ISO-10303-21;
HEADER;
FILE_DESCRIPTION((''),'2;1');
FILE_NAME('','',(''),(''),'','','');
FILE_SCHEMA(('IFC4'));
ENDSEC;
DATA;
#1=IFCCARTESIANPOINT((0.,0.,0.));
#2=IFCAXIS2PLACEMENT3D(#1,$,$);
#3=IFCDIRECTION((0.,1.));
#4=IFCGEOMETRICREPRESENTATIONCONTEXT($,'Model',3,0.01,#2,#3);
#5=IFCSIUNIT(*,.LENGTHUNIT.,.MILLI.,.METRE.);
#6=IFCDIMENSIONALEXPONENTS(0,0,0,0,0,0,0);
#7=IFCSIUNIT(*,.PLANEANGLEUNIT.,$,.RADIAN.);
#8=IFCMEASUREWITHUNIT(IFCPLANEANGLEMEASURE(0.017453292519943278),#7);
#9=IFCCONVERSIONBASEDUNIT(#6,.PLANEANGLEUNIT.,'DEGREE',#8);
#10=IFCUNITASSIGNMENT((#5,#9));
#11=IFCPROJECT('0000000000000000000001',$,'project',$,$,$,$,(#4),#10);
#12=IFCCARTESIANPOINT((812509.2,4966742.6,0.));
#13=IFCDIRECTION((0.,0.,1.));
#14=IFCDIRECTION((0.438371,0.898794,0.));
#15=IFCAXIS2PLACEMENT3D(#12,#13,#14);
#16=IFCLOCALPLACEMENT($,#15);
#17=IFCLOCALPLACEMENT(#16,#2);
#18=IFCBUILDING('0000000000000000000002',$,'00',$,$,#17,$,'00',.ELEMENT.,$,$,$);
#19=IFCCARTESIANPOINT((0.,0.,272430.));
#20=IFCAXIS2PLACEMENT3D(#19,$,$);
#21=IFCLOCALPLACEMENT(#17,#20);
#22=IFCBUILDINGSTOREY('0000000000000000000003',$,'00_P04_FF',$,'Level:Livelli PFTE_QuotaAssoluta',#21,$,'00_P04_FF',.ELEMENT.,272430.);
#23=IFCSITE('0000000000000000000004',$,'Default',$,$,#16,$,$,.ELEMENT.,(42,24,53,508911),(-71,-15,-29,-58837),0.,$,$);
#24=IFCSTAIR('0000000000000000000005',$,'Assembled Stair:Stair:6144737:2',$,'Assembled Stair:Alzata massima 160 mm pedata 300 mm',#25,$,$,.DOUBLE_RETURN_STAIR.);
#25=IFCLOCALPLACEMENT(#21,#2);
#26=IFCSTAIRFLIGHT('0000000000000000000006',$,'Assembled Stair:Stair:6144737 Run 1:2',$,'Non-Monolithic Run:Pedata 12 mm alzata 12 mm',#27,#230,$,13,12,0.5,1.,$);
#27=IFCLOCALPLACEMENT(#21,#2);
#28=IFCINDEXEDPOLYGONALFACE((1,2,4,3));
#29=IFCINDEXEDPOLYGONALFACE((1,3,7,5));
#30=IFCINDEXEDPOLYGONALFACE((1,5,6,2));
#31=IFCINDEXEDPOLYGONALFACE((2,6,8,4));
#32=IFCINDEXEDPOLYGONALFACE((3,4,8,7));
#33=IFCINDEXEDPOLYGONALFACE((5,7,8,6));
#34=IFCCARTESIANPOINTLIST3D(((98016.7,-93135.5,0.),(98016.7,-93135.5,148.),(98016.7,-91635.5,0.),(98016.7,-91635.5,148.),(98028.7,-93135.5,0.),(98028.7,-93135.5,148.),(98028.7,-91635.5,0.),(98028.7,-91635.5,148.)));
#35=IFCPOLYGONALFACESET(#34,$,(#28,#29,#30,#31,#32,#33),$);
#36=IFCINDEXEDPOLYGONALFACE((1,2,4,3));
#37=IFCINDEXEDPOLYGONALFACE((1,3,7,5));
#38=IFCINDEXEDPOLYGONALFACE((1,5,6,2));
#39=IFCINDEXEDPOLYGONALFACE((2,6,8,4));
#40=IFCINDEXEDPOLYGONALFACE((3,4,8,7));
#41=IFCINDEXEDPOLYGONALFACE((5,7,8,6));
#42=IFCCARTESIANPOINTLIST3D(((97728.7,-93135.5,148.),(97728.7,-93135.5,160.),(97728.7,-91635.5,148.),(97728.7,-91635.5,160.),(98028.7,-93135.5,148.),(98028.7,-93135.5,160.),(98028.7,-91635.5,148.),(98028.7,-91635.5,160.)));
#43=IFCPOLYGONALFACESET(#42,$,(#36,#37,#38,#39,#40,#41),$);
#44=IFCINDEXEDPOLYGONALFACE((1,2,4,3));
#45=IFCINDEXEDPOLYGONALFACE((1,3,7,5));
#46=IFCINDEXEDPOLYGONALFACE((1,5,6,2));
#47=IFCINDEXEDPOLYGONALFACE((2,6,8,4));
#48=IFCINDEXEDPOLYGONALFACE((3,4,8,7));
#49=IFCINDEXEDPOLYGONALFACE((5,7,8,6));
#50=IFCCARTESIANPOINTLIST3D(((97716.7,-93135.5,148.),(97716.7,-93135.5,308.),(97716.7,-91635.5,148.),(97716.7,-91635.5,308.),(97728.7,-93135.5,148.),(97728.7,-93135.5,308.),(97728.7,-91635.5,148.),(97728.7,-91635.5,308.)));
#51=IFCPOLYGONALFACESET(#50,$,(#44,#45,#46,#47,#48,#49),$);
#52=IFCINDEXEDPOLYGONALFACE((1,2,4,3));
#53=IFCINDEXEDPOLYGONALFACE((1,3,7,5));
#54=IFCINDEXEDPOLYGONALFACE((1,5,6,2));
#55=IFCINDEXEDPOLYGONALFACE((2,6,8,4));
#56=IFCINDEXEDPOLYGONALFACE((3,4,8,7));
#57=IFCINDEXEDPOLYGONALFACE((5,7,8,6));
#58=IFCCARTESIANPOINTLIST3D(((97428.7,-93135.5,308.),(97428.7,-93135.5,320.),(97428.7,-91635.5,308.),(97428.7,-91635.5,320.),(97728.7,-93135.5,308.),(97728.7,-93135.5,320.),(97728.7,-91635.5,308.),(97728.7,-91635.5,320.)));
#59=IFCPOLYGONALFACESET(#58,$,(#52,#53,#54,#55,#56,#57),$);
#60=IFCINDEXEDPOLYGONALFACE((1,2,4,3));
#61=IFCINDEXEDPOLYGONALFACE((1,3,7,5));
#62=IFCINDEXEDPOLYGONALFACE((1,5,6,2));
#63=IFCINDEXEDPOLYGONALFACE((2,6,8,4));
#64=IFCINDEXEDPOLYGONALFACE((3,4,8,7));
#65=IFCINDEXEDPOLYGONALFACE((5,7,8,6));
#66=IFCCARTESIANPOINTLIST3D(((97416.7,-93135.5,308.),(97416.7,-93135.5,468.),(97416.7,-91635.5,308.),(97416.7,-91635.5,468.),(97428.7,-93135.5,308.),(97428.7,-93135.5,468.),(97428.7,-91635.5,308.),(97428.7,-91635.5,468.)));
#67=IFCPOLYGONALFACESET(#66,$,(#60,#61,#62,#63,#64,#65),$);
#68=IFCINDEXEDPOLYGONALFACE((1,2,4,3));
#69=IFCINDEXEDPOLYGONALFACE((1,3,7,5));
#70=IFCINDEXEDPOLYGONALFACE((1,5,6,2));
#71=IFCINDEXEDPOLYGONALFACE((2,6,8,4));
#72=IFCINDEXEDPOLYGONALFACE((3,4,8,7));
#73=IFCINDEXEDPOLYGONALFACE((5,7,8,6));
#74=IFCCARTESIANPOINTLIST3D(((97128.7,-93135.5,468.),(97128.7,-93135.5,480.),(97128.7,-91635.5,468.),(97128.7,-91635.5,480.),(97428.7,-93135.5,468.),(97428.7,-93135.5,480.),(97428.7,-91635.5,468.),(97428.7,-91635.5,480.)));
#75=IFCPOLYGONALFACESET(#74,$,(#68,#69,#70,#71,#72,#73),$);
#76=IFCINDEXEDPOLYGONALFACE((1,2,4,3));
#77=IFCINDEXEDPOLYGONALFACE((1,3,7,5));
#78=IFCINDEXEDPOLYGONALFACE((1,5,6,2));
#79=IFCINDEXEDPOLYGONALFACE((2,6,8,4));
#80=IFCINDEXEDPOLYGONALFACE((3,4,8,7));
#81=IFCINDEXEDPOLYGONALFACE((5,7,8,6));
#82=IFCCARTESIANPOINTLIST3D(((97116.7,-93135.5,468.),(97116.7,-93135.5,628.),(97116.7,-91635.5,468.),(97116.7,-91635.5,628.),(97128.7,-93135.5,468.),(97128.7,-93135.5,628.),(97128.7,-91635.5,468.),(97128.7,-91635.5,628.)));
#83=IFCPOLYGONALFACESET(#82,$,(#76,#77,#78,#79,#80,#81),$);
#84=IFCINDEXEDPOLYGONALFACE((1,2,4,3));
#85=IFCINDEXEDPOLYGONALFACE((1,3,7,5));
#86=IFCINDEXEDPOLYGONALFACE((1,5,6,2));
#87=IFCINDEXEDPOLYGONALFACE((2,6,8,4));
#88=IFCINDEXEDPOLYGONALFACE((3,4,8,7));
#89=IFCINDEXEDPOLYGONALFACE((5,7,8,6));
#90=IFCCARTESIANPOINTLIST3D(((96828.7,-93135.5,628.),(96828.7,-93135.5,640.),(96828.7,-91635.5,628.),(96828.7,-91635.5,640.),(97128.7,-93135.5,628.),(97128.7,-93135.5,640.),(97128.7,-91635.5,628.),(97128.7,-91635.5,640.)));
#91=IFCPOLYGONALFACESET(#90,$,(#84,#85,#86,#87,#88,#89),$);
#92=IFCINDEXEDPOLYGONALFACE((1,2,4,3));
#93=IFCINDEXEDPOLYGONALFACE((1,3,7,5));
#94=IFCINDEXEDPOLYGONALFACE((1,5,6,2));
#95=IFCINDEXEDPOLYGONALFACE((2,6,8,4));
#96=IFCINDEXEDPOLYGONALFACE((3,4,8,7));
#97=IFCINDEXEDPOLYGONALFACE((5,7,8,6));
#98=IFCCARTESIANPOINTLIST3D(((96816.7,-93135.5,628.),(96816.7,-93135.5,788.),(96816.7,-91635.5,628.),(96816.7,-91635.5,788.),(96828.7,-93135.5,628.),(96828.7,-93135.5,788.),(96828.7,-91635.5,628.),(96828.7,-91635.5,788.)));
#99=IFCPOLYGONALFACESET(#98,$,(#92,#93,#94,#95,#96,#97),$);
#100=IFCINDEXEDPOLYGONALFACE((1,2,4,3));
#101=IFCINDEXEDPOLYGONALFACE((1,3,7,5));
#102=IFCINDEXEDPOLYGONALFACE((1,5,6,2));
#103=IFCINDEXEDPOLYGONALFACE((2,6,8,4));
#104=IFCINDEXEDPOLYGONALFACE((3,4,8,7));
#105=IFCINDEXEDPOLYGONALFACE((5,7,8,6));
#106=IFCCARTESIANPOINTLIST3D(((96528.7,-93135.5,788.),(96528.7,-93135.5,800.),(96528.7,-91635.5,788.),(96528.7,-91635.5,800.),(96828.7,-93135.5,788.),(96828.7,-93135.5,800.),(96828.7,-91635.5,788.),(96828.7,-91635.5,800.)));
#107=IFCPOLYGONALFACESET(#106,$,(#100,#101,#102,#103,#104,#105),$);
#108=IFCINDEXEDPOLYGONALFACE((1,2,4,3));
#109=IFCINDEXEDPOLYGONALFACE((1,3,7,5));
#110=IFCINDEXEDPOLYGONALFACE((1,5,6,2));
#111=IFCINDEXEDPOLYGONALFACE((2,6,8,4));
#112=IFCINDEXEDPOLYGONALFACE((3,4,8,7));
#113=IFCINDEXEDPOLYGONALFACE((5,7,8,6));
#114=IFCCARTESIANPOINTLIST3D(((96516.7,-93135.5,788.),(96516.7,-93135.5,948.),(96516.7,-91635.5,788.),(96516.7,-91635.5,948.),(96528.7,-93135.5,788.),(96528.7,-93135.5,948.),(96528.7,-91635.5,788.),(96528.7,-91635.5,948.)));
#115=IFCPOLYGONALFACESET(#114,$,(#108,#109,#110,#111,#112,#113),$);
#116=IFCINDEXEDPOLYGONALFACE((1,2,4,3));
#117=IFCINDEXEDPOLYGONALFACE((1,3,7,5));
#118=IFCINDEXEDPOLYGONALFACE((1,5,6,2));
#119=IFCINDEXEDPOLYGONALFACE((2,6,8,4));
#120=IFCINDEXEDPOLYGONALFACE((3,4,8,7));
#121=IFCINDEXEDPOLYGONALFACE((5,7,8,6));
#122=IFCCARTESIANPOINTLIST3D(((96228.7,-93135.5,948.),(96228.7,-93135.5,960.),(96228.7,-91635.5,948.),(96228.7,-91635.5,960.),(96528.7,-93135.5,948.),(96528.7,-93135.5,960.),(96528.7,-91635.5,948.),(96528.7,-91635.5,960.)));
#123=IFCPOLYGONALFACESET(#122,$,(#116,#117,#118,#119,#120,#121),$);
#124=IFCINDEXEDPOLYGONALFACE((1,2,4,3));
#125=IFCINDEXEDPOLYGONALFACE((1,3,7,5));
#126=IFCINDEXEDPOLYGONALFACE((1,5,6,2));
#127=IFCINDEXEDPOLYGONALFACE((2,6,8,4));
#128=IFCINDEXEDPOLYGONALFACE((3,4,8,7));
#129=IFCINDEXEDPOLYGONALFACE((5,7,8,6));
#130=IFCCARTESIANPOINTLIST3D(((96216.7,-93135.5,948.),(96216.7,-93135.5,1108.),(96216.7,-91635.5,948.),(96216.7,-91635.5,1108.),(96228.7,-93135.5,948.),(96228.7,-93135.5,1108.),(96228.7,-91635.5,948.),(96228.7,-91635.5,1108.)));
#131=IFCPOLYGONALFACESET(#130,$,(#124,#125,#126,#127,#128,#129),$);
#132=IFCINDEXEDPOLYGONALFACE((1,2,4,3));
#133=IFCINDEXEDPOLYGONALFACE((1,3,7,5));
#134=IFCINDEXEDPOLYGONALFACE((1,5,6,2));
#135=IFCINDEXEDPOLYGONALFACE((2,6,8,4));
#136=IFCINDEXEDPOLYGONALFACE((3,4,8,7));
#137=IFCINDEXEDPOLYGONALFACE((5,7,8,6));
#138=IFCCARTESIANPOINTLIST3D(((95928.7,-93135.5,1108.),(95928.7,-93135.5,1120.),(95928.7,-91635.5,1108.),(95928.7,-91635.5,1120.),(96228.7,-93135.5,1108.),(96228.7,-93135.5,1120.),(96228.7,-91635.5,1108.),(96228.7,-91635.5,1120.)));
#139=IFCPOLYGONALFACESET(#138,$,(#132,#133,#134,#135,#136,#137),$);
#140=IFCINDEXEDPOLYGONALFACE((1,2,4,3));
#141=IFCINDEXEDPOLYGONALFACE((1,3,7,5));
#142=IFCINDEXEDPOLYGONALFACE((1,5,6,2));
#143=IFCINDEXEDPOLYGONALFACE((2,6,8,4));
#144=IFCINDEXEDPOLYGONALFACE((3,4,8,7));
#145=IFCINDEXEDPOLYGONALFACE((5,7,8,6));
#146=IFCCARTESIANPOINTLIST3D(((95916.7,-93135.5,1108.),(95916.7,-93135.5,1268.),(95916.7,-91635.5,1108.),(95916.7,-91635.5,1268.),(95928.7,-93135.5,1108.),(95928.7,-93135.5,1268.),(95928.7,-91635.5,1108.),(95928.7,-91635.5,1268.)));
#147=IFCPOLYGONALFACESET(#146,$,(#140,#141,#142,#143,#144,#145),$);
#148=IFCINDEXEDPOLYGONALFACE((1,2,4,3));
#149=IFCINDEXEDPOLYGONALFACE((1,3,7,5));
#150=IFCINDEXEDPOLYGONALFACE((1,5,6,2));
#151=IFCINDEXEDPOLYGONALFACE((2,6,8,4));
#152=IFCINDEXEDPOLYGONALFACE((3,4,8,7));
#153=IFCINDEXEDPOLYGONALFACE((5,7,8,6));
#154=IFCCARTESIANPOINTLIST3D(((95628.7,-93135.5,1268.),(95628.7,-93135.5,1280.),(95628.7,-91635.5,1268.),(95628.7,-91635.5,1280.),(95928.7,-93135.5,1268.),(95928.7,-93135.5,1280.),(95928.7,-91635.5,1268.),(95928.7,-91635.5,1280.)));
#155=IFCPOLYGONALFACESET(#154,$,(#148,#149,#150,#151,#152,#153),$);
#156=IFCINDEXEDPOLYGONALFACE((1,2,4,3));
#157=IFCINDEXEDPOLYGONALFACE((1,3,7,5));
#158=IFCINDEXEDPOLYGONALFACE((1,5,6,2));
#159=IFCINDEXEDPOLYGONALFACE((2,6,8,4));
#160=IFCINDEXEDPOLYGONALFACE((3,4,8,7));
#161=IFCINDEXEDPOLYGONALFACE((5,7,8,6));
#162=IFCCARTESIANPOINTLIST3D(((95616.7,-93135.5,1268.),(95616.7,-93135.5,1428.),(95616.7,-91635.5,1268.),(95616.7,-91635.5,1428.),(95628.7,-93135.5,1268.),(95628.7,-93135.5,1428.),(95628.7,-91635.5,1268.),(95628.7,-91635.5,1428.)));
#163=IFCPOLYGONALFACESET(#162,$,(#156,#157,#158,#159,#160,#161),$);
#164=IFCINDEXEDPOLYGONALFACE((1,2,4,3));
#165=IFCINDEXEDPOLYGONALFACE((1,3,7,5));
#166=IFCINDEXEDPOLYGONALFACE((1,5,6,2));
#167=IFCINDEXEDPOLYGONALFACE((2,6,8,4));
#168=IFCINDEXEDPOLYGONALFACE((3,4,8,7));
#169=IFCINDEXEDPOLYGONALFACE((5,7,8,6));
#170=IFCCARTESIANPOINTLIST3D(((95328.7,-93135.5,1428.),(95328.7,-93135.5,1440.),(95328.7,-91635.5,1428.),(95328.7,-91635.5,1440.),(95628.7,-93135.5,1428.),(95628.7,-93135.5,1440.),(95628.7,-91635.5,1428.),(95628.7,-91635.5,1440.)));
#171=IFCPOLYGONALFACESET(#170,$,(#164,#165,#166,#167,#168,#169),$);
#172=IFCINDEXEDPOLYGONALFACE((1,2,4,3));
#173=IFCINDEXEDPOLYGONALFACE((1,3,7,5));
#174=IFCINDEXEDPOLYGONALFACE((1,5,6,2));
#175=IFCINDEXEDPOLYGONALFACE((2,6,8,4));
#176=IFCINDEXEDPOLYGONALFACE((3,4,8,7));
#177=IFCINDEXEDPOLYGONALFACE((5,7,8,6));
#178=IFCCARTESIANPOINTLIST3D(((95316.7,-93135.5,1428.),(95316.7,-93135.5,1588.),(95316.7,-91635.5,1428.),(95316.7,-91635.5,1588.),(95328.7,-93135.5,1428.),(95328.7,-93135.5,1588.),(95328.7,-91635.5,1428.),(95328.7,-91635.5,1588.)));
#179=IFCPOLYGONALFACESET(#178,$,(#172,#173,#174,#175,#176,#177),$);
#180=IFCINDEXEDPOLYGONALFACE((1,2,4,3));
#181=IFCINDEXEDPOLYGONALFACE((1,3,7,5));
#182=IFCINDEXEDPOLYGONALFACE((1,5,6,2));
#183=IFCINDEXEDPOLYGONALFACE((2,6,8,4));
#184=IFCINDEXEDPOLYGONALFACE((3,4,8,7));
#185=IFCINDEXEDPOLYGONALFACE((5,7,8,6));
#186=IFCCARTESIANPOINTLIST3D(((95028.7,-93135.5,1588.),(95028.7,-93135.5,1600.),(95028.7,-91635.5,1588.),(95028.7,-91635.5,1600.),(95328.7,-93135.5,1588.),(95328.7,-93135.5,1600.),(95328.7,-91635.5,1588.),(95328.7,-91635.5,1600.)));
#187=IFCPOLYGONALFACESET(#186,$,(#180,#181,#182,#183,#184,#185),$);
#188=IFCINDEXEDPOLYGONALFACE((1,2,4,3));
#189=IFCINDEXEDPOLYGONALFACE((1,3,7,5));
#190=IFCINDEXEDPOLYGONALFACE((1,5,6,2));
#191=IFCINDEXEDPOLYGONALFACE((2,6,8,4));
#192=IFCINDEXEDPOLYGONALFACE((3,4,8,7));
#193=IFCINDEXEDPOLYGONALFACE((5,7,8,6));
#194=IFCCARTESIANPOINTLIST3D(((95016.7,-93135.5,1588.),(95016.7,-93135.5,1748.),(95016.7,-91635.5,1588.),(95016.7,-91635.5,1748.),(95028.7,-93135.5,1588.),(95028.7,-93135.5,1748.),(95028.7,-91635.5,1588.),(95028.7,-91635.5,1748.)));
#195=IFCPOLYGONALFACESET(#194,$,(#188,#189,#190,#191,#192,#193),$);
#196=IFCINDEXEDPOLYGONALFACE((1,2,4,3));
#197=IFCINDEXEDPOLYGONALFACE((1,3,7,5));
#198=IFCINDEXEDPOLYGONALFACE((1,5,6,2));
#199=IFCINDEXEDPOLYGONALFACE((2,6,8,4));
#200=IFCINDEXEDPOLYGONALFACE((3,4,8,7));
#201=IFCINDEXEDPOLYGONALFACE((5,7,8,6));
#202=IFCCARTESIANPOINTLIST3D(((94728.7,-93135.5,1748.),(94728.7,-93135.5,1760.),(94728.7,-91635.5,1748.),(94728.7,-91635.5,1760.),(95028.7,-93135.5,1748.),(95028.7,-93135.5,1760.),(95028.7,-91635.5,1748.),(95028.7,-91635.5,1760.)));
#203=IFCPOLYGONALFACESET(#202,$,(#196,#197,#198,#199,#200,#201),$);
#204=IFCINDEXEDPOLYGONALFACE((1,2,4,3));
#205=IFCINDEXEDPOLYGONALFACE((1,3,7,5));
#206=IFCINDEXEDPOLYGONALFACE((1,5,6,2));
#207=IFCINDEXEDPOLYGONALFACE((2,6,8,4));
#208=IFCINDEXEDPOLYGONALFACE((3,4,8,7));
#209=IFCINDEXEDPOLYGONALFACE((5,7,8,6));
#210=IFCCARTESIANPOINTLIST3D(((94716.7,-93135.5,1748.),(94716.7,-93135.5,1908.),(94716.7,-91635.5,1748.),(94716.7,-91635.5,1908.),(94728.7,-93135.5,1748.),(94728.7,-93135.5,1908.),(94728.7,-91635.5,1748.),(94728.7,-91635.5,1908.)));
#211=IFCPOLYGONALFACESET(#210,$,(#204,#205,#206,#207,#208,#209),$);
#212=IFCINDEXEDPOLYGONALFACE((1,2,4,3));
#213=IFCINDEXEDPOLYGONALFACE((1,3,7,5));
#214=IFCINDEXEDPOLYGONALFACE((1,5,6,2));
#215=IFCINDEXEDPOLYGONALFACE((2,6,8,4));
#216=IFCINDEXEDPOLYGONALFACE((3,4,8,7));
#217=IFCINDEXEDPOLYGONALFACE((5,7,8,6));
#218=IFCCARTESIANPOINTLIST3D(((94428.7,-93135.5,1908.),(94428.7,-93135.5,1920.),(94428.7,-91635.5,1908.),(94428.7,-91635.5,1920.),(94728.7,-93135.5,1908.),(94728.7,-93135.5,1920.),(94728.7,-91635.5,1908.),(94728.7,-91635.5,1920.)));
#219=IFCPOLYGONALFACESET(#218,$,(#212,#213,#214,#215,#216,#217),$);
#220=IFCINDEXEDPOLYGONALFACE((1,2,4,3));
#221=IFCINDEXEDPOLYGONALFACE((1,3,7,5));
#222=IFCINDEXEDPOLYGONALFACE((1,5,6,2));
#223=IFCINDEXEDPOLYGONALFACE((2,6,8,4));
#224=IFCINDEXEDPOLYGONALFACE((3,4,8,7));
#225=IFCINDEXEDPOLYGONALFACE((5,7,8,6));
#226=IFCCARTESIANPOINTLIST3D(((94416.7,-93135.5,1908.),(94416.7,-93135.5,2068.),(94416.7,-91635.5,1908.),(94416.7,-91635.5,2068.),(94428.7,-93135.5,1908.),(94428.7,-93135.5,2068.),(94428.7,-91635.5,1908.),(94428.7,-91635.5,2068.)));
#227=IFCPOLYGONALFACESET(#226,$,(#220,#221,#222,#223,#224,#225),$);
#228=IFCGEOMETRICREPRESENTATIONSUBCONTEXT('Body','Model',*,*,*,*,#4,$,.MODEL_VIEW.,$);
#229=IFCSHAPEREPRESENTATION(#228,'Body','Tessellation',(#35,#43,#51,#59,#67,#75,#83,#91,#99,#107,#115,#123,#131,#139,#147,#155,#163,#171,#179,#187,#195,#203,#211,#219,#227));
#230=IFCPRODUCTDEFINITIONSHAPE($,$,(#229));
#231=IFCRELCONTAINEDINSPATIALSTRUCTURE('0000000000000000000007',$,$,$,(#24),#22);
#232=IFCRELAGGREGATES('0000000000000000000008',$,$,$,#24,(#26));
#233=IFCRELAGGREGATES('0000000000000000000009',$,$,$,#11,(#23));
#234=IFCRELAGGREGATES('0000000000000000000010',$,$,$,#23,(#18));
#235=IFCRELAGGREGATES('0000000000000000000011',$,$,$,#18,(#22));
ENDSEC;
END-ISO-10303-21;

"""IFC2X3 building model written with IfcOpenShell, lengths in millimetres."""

from ifc_helpers import new_model, entity, si_unit, converted_unit, direction, frame, frame_2d, origin, origin_2d_with_axis, place, context, subcontext, project, spatial, rectangle, extrude, element, aggregate, save


model = new_model("IFC2X3")

# Units and contexts
model_context = context("Model", 3, precision=0.01, world=origin(), true_north=direction((0.0, 1.0)))
body_context = subcontext(model_context, "Body", "Model", "MODEL_VIEW")
ifc_project = project(units=[si_unit("LENGTHUNIT", "METRE", prefix="MILLI"), converted_unit("PLANEANGLEUNIT", "DEGREE", entity("IfcPlaneAngleMeasure", 0.017453292519943278), si_unit("PLANEANGLEUNIT", "RADIAN"), dimensions=[0, 0, 0, 0, 0, 0, 0])], contexts=[model_context])

# Site, building, storey
site_placement = place(None, frame((812509.2, 4966742.6, 0.0), z_axis=(0.0, 0.0, 1.0), x_axis=(0.438371, 0.898794, 0.0)))
site = spatial("IfcSite", under=ifc_project, at=site_placement, Name="Default", CompositionType="ELEMENT", RefLatitude=(42, 24, 53, 508911), RefLongitude=(-71, -15, -29, -58837), RefElevation=0.0)
building_placement = place(site_placement, origin())
building = spatial("IfcBuilding", under=site, at=building_placement, Name="00", LongName="00", CompositionType="ELEMENT")
storey_placement = place(building_placement, frame((0.0, 0.0, 272430.0)))
storey = spatial("IfcBuildingStorey", under=building, at=storey_placement, Name="00_P04_FF", ObjectType="Level:Livelli PFTE_QuotaAssoluta", LongName="00_P04_FF", CompositionType="ELEMENT", Elevation=272430.0)

# Stair
stair_1_placement = place(storey_placement, origin())
stair_1 = element("IfcStair", 1, at=stair_1_placement, inside=storey, Name="Assembled Stair:Stair:6144737:2", ObjectType="Assembled Stair:Alzata massima 160 mm pedata 300 mm", ShapeType="DOUBLE_RETURN_STAIR")

# Stair flight
stair_flight_1_placement = place(stair_1_placement, origin())
stair_flight_1 = element("IfcStairFlight", 2, at=stair_flight_1_placement, Name="Assembled Stair:Stair:6144737 Run 1:2", ObjectType="Non-Monolithic Run:Pedata 12 mm alzata 12 mm", NumberOfRiser=13, NumberOfTreads=12, RiserHeight=0.5, TreadLength=1.0, context=body_context, shape_type="SweptSolid", body=[
    extrude(rectangle(XDim=1500.0, YDim=12.0, at=frame_2d((0.0, 0.0), x_axis=(1.0, 0.0))), frame((98022.7, -92385.5, 0.0), z_axis=(0.0, 0.0, 1.0), x_axis=(0.0, -1.0, 0.0)), (0.0, 0.0, 1.0), 148.0),
    extrude(rectangle(XDim=300.0, YDim=1500.0, at=frame_2d((0.0, 0.0), x_axis=(1.0, 0.0))), frame((97878.7, -92385.5, 148.0)), (0.0, 0.0, 1.0), 12.0),
    extrude(rectangle(XDim=1500.0, YDim=12.0, at=origin_2d_with_axis()), frame((97722.7, -92385.5, 148.0), z_axis=(0.0, 0.0, 1.0), x_axis=(0.0, -1.0, 0.0)), (0.0, 0.0, 1.0), 160.0),
    extrude(rectangle(XDim=300.0, YDim=1500.0, at=origin_2d_with_axis()), frame((97578.7, -92385.5, 308.0)), (0.0, 0.0, 1.0), 12.0),
    extrude(rectangle(XDim=1500.0, YDim=12.0, at=origin_2d_with_axis()), frame((97422.7, -92385.5, 308.0), z_axis=(0.0, 0.0, 1.0), x_axis=(0.0, -1.0, 0.0)), (0.0, 0.0, 1.0), 160.0),
    extrude(rectangle(XDim=300.0, YDim=1500.0, at=origin_2d_with_axis()), frame((97278.7, -92385.5, 468.0)), (0.0, 0.0, 1.0), 12.0),
    extrude(rectangle(XDim=1500.0, YDim=12.0, at=origin_2d_with_axis()), frame((97122.7, -92385.5, 468.0), z_axis=(0.0, 0.0, 1.0), x_axis=(0.0, -1.0, 0.0)), (0.0, 0.0, 1.0), 160.0),
    extrude(rectangle(XDim=300.0, YDim=1500.0, at=origin_2d_with_axis()), frame((96978.7, -92385.5, 628.0)), (0.0, 0.0, 1.0), 12.0),
    extrude(rectangle(XDim=1500.0, YDim=12.0, at=origin_2d_with_axis()), frame((96822.7, -92385.5, 628.0), z_axis=(0.0, 0.0, 1.0), x_axis=(0.0, -1.0, 0.0)), (0.0, 0.0, 1.0), 160.0),
    extrude(rectangle(XDim=300.0, YDim=1500.0, at=origin_2d_with_axis()), frame((96678.7, -92385.5, 788.0)), (0.0, 0.0, 1.0), 12.0),
    extrude(rectangle(XDim=1500.0, YDim=12.0, at=origin_2d_with_axis()), frame((96522.7, -92385.5, 788.0), z_axis=(0.0, 0.0, 1.0), x_axis=(0.0, -1.0, 0.0)), (0.0, 0.0, 1.0), 160.0),
    extrude(rectangle(XDim=300.0, YDim=1500.0, at=origin_2d_with_axis()), frame((96378.7, -92385.5, 948.0)), (0.0, 0.0, 1.0), 12.0),
    extrude(rectangle(XDim=1500.0, YDim=12.0, at=origin_2d_with_axis()), frame((96222.7, -92385.5, 948.0), z_axis=(0.0, 0.0, 1.0), x_axis=(0.0, -1.0, 0.0)), (0.0, 0.0, 1.0), 160.0),
    extrude(rectangle(XDim=300.0, YDim=1500.0, at=origin_2d_with_axis()), frame((96078.7, -92385.5, 1108.0)), (0.0, 0.0, 1.0), 12.0),
    extrude(rectangle(XDim=1500.0, YDim=12.0, at=origin_2d_with_axis()), frame((95922.7, -92385.5, 1108.0), z_axis=(0.0, 0.0, 1.0), x_axis=(0.0, -1.0, 0.0)), (0.0, 0.0, 1.0), 160.0),
    extrude(rectangle(XDim=300.0, YDim=1500.0, at=origin_2d_with_axis()), frame((95778.7, -92385.5, 1268.0)), (0.0, 0.0, 1.0), 12.0),
    extrude(rectangle(XDim=1500.0, YDim=12.0, at=origin_2d_with_axis()), frame((95622.7, -92385.5, 1268.0), z_axis=(0.0, 0.0, 1.0), x_axis=(0.0, -1.0, 0.0)), (0.0, 0.0, 1.0), 160.0),
    extrude(rectangle(XDim=300.0, YDim=1500.0, at=origin_2d_with_axis()), frame((95478.7, -92385.5, 1428.0)), (0.0, 0.0, 1.0), 12.0),
    extrude(rectangle(XDim=1500.0, YDim=12.0, at=origin_2d_with_axis()), frame((95322.7, -92385.5, 1428.0), z_axis=(0.0, 0.0, 1.0), x_axis=(0.0, -1.0, 0.0)), (0.0, 0.0, 1.0), 160.0),
    extrude(rectangle(XDim=300.0, YDim=1500.0, at=origin_2d_with_axis()), frame((95178.7, -92385.5, 1588.0)), (0.0, 0.0, 1.0), 12.0),
    extrude(rectangle(XDim=1500.0, YDim=12.0, at=origin_2d_with_axis()), frame((95022.7, -92385.5, 1588.0), z_axis=(0.0, 0.0, 1.0), x_axis=(0.0, -1.0, 0.0)), (0.0, 0.0, 1.0), 160.0),
    extrude(rectangle(XDim=300.0, YDim=1500.0, at=origin_2d_with_axis()), frame((94878.7, -92385.5, 1748.0)), (0.0, 0.0, 1.0), 12.0),
    extrude(rectangle(XDim=1500.0, YDim=12.0, at=origin_2d_with_axis()), frame((94722.7, -92385.5, 1748.0), z_axis=(0.0, 0.0, 1.0), x_axis=(0.0, -1.0, 0.0)), (0.0, 0.0, 1.0), 160.0),
    extrude(rectangle(XDim=300.0, YDim=1500.0, at=origin_2d_with_axis()), frame((94578.7, -92385.5, 1908.0)), (0.0, 0.0, 1.0), 12.0),
    extrude(rectangle(XDim=1500.0, YDim=12.0, at=origin_2d_with_axis()), frame((94422.7, -92385.5, 1908.0), z_axis=(0.0, 0.0, 1.0), x_axis=(0.0, -1.0, 0.0)), (0.0, 0.0, 1.0), 160.0),
])
aggregate(stair_1, [stair_flight_1])

save(model, "model.ifc")
